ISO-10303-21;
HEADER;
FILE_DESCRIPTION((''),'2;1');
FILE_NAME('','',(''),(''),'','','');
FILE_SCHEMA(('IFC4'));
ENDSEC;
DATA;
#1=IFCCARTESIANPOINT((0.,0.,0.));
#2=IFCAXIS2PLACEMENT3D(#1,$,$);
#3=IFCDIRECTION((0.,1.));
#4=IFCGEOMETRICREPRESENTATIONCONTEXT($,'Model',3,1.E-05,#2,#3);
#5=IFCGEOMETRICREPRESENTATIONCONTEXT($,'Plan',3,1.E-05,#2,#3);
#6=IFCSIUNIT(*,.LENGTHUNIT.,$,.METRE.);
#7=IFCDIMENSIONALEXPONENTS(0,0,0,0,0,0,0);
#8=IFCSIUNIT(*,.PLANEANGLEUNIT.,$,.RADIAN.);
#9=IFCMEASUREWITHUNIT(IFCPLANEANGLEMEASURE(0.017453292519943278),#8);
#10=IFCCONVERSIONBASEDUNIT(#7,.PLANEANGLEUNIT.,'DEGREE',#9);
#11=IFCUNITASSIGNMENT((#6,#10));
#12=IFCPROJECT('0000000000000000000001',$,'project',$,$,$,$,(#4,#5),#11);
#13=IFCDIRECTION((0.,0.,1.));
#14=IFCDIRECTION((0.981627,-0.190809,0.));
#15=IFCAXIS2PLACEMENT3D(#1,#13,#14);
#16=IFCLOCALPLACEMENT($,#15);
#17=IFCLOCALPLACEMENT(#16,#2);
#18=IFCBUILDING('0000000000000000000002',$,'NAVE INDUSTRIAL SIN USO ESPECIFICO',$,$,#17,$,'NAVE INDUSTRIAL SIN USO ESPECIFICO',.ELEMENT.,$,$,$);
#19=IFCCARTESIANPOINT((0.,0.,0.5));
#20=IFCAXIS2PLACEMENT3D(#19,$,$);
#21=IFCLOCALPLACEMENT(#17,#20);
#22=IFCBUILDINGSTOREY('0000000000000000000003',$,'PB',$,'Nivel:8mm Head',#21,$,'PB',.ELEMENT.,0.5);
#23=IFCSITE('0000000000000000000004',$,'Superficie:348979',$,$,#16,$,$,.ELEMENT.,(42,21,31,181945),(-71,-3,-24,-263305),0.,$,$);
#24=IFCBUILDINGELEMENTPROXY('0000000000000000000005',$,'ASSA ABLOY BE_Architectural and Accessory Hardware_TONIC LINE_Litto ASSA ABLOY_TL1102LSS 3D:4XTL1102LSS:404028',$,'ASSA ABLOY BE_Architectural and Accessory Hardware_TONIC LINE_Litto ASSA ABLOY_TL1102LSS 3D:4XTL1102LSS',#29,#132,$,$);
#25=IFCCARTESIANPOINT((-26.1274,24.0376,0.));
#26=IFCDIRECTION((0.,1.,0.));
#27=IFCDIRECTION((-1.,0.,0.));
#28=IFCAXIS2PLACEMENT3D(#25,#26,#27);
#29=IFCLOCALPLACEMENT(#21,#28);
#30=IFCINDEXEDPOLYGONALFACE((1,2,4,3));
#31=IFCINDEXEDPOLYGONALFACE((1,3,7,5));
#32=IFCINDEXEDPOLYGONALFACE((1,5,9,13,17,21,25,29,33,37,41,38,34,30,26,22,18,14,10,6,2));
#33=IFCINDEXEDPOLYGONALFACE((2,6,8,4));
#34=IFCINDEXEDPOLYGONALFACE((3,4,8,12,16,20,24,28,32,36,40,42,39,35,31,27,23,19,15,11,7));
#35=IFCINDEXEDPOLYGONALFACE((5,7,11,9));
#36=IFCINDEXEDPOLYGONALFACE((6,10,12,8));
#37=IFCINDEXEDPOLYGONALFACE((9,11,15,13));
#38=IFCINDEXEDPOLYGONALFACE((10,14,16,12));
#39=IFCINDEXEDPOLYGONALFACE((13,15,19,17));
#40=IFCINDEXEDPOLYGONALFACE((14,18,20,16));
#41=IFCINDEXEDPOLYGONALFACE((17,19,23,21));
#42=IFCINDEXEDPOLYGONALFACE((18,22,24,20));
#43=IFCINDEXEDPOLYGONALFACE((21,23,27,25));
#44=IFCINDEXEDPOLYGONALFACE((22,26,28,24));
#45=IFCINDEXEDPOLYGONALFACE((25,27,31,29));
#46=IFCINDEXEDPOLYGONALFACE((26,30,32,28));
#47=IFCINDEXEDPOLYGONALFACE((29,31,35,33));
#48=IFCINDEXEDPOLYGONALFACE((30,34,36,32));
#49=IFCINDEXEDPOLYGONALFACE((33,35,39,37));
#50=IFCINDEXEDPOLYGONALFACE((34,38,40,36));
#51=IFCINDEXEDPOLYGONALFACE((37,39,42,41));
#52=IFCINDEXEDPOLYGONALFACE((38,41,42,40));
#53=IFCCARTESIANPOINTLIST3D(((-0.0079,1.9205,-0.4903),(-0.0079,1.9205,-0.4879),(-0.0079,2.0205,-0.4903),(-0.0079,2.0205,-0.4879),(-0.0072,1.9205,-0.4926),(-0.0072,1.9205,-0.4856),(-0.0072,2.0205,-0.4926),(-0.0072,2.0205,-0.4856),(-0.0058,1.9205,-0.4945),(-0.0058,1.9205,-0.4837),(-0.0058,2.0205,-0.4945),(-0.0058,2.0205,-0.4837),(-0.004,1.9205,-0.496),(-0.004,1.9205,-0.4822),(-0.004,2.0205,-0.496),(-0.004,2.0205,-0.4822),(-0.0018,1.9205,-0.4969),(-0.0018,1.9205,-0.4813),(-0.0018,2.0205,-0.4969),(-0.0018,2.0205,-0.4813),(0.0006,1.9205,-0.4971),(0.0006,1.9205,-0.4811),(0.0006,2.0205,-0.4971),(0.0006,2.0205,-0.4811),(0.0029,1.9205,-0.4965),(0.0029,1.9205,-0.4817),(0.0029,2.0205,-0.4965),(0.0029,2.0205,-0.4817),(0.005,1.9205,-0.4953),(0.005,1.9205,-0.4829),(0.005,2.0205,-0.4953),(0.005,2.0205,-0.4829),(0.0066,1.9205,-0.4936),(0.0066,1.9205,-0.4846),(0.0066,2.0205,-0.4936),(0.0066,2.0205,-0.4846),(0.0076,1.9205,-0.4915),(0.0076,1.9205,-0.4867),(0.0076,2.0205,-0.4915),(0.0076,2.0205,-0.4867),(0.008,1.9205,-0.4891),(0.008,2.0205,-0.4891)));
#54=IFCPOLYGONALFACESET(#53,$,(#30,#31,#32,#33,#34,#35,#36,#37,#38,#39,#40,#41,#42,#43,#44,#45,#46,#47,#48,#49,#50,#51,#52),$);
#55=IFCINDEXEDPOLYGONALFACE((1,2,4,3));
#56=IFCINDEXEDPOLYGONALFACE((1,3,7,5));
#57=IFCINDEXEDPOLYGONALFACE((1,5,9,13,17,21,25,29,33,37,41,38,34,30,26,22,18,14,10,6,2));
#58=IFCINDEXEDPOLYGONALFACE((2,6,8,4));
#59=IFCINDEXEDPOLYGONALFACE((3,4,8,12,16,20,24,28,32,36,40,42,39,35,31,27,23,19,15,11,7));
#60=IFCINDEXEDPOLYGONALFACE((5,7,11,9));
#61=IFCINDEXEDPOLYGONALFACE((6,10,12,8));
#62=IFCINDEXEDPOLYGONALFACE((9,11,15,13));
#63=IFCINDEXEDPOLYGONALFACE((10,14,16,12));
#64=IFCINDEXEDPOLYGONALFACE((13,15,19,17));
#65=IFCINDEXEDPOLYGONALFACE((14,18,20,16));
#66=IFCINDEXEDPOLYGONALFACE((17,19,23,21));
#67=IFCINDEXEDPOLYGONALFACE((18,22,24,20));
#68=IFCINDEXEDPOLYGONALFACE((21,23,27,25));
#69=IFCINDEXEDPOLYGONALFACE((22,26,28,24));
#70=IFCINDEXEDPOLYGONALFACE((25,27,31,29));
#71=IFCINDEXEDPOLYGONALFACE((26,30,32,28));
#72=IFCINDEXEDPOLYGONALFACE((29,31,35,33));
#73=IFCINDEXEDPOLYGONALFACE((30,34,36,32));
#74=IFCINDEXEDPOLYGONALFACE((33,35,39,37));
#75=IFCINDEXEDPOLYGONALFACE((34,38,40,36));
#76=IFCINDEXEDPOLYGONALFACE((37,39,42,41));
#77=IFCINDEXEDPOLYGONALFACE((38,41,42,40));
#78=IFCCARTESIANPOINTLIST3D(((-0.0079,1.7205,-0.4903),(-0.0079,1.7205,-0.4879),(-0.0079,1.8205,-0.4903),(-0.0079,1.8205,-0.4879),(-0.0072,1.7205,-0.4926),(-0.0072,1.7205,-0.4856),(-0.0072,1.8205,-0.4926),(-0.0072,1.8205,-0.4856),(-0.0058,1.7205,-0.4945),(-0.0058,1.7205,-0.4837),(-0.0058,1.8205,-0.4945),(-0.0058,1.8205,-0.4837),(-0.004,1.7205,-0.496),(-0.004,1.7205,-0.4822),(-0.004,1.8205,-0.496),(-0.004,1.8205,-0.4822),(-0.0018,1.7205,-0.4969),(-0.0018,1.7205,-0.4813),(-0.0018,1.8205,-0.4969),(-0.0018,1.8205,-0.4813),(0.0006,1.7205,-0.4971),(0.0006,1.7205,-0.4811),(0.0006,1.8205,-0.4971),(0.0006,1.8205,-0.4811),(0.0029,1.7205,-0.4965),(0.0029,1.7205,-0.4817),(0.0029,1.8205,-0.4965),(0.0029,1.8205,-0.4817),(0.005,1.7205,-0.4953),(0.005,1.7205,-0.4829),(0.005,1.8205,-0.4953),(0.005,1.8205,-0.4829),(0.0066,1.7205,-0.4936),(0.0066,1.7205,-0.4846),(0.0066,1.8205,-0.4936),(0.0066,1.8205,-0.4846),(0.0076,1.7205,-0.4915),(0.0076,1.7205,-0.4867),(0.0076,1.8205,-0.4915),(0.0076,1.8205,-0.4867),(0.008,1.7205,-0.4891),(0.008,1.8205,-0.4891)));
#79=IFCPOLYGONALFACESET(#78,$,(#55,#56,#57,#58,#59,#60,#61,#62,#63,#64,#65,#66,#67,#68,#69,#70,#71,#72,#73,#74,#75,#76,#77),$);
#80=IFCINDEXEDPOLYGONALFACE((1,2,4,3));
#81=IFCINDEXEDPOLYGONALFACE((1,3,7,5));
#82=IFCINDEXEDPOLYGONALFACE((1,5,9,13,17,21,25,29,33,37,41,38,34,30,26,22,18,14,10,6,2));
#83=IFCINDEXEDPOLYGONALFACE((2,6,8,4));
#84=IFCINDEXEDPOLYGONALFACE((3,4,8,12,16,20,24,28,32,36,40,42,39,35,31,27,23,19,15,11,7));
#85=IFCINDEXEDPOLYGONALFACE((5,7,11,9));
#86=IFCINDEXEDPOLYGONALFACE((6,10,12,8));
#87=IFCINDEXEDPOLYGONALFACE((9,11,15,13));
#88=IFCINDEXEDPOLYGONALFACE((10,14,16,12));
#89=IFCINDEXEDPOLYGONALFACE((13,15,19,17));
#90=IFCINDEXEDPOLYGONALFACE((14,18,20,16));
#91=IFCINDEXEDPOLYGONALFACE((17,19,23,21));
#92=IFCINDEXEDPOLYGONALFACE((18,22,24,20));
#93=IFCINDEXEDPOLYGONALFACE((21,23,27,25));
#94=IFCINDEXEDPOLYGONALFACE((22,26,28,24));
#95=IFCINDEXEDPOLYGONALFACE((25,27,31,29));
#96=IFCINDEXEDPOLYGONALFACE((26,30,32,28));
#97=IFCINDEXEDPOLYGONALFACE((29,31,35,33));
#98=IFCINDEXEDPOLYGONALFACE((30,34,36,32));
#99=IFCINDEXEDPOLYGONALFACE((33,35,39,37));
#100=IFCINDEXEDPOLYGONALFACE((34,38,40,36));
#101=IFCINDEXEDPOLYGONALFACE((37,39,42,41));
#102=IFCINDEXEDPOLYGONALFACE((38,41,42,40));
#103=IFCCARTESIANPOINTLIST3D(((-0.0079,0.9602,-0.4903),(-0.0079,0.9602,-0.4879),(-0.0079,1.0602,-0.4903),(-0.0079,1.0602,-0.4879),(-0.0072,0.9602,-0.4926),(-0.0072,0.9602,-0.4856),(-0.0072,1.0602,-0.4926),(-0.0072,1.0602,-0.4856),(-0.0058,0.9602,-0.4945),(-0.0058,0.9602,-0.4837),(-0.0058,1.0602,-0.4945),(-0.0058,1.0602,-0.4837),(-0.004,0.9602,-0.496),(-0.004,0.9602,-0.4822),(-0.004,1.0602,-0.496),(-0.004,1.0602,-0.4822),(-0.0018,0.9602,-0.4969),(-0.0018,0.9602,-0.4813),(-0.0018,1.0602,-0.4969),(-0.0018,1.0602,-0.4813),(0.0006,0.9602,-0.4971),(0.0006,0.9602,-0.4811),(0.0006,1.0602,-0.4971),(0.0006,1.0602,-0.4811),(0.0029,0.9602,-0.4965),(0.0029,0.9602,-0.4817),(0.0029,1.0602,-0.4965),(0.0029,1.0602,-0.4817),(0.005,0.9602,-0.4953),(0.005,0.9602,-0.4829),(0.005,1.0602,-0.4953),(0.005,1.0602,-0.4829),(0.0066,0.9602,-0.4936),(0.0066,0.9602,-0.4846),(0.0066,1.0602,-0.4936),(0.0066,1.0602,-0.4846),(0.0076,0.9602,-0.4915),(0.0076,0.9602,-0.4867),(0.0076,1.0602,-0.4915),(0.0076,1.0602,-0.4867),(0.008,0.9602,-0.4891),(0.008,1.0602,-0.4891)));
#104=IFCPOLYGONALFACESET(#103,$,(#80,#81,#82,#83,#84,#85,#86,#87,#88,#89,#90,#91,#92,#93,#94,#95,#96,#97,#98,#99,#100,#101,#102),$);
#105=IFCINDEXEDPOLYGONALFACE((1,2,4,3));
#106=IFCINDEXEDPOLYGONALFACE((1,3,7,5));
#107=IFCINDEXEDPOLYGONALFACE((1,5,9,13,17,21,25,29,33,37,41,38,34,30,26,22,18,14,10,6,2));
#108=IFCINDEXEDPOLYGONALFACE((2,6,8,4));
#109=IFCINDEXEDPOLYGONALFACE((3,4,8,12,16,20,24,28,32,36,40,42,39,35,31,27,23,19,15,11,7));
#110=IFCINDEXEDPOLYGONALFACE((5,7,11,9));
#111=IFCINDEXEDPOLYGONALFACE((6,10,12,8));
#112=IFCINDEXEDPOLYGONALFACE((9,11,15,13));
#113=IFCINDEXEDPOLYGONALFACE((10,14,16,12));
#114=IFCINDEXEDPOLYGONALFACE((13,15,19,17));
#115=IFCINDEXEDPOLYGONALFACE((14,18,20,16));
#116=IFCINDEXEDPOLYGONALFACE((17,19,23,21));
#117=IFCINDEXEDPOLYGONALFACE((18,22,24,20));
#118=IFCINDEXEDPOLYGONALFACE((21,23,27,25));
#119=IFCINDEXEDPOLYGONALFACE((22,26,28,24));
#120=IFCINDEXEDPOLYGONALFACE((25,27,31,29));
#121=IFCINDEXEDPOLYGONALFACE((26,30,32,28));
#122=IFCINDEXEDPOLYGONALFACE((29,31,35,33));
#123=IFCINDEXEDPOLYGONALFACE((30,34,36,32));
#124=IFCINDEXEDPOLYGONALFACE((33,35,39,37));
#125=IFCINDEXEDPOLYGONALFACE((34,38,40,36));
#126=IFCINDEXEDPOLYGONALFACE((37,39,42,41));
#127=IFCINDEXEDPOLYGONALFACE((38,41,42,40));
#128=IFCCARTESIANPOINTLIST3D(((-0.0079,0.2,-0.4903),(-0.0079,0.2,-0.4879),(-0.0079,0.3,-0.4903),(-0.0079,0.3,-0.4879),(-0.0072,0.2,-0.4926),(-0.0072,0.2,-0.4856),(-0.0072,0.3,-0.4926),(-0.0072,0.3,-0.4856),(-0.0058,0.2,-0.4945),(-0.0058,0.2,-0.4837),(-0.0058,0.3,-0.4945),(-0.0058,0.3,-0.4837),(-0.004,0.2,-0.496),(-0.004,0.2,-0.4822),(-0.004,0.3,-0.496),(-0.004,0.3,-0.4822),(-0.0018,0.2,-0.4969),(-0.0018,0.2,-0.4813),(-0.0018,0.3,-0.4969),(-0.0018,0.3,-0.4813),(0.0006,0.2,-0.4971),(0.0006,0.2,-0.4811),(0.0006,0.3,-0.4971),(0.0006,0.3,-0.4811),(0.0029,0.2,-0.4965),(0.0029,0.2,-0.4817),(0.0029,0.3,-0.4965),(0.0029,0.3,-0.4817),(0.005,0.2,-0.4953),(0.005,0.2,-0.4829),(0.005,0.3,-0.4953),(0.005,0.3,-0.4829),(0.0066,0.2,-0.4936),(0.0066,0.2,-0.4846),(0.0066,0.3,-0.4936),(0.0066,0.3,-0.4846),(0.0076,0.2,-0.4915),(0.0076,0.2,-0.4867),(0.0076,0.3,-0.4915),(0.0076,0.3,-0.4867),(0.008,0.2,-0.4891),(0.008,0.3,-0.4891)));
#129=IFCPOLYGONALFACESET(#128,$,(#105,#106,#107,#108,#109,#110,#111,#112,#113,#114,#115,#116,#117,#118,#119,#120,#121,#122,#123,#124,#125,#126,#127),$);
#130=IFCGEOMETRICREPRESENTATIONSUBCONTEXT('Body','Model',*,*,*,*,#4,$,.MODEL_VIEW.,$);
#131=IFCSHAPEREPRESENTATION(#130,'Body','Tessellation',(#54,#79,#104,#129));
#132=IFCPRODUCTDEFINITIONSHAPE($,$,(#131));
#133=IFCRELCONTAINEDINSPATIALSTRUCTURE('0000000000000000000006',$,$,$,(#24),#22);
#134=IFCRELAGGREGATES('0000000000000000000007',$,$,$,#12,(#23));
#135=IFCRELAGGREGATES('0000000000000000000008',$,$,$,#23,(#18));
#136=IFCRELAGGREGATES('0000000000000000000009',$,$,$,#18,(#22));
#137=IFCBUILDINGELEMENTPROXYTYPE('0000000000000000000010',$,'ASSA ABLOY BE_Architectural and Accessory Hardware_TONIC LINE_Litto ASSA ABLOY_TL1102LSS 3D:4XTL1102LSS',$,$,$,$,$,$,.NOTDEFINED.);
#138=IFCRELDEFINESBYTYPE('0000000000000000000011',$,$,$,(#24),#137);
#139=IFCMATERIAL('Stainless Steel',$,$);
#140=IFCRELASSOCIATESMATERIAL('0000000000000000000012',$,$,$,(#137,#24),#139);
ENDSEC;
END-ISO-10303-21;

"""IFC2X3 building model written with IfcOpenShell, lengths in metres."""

from ifc_helpers import new_model, entity, si_unit, converted_unit, direction, frame, frame_2d, origin, place, context, subcontext, project, spatial, circle, extrude, source, transform, mapped, material, type_object, type_shapes, element, save


model = new_model("IFC2X3")

# Units and contexts
model_context = context("Model", 3, precision=1e-05, world=origin(), true_north=direction((0.0, 1.0)))
plan_context = context("Plan", 3, precision=1e-05, world=origin(), true_north=direction((0.0, 1.0)))
body_context = subcontext(model_context, "Body", "Model", "MODEL_VIEW")
ifc_project = project(units=[si_unit("LENGTHUNIT", "METRE"), converted_unit("PLANEANGLEUNIT", "DEGREE", entity("IfcPlaneAngleMeasure", 0.017453292519943278), si_unit("PLANEANGLEUNIT", "RADIAN"), dimensions=[0, 0, 0, 0, 0, 0, 0])], contexts=[model_context, plan_context])

# Site, building, storey
site_placement = place(None, frame((0.0, 0.0, 0.0), z_axis=(0.0, 0.0, 1.0), x_axis=(0.981627, -0.190809, 0.0)))
site = spatial("IfcSite", under=ifc_project, at=site_placement, Name="Superficie:348979", CompositionType="ELEMENT", RefLatitude=(42, 21, 31, 181945), RefLongitude=(-71, -3, -24, -263305), RefElevation=0.0)
building_placement = place(site_placement, origin())
building = spatial("IfcBuilding", under=site, at=building_placement, Name="NAVE INDUSTRIAL SIN USO ESPECIFICO", LongName="NAVE INDUSTRIAL SIN USO ESPECIFICO", CompositionType="ELEMENT")
storey_placement = place(building_placement, frame((0.0, 0.0, 0.5)))
storey = spatial("IfcBuildingStorey", under=building, at=storey_placement, Name="PB", ObjectType="Nivel:8mm Head", LongName="PB", CompositionType="ELEMENT", Elevation=0.5)

# Building element proxy
ifc_material_1 = material(Name="Stainless Steel")
building_element_proxy_type_1 = type_object("IfcBuildingElementProxyType", Name="ASSA ABLOY BE_Architectural and Accessory Hardware_TONIC LINE_Litto ASSA ABLOY_TL1102LSS 3D:4XTL1102LSS", PredefinedType="NOTDEFINED", material=ifc_material_1)
shared_shape_1 = source(origin(), body_context, "Body", "SweptSolid", [
    extrude(circle(Radius=0.008, at=frame_2d((0.0, 0.0), x_axis=(1.0, 0.0))), frame((0.0, 1.9205, -0.4891), z_axis=(0.0, 1.0, 0.0), x_axis=(1.0, 0.0, 0.0)), (0.0, 0.0, 1.0), 0.1),
    extrude(circle(Radius=0.008, at=frame_2d((0.0, 0.0), x_axis=(1.0, 0.0))), frame((0.0, 1.7205, -0.4891), z_axis=(0.0, 1.0, 0.0), x_axis=(1.0, 0.0, 0.0)), (0.0, 0.0, 1.0), 0.1),
    extrude(circle(Radius=0.008, at=frame_2d((0.0, 0.0), x_axis=(1.0, 0.0))), frame((0.0, 0.9602, -0.4891), z_axis=(0.0, 1.0, 0.0), x_axis=(1.0, 0.0, 0.0)), (0.0, 0.0, 1.0), 0.1),
    extrude(circle(Radius=0.008, at=frame_2d((0.0, 0.0), x_axis=(1.0, 0.0))), frame((0.0, 0.2, -0.4891), z_axis=(0.0, 1.0, 0.0), x_axis=(1.0, 0.0, 0.0)), (0.0, 0.0, 1.0), 0.1),
])
type_shapes(building_element_proxy_type_1, [shared_shape_1])
for number, where, z_axis, x_axis, name in (
    (1, (-26.1274, 24.0376, 0.0), (0.0, 1.0, 0.0), (-1.0, 0.0, 0.0), "ASSA ABLOY BE_Architectural and Accessory Hardware_TONIC LINE_Litto ASSA ABLOY_TL1102LSS 3D:4XTL1102LSS:404028"),
):
    element("IfcBuildingElementProxy", number, at=place(storey_placement, frame(where, z_axis=z_axis, x_axis=x_axis)), inside=storey, type_object=building_element_proxy_type_1, material=ifc_material_1, Name=name, ObjectType="ASSA ABLOY BE_Architectural and Accessory Hardware_TONIC LINE_Litto ASSA ABLOY_TL1102LSS 3D:4XTL1102LSS", context=body_context, shape_type="MappedRepresentation", body=[
        mapped(shared_shape_1, transform((0.0, 0.0, 0.0), scale=1.0)),
    ])

save(model, "model.ifc")
